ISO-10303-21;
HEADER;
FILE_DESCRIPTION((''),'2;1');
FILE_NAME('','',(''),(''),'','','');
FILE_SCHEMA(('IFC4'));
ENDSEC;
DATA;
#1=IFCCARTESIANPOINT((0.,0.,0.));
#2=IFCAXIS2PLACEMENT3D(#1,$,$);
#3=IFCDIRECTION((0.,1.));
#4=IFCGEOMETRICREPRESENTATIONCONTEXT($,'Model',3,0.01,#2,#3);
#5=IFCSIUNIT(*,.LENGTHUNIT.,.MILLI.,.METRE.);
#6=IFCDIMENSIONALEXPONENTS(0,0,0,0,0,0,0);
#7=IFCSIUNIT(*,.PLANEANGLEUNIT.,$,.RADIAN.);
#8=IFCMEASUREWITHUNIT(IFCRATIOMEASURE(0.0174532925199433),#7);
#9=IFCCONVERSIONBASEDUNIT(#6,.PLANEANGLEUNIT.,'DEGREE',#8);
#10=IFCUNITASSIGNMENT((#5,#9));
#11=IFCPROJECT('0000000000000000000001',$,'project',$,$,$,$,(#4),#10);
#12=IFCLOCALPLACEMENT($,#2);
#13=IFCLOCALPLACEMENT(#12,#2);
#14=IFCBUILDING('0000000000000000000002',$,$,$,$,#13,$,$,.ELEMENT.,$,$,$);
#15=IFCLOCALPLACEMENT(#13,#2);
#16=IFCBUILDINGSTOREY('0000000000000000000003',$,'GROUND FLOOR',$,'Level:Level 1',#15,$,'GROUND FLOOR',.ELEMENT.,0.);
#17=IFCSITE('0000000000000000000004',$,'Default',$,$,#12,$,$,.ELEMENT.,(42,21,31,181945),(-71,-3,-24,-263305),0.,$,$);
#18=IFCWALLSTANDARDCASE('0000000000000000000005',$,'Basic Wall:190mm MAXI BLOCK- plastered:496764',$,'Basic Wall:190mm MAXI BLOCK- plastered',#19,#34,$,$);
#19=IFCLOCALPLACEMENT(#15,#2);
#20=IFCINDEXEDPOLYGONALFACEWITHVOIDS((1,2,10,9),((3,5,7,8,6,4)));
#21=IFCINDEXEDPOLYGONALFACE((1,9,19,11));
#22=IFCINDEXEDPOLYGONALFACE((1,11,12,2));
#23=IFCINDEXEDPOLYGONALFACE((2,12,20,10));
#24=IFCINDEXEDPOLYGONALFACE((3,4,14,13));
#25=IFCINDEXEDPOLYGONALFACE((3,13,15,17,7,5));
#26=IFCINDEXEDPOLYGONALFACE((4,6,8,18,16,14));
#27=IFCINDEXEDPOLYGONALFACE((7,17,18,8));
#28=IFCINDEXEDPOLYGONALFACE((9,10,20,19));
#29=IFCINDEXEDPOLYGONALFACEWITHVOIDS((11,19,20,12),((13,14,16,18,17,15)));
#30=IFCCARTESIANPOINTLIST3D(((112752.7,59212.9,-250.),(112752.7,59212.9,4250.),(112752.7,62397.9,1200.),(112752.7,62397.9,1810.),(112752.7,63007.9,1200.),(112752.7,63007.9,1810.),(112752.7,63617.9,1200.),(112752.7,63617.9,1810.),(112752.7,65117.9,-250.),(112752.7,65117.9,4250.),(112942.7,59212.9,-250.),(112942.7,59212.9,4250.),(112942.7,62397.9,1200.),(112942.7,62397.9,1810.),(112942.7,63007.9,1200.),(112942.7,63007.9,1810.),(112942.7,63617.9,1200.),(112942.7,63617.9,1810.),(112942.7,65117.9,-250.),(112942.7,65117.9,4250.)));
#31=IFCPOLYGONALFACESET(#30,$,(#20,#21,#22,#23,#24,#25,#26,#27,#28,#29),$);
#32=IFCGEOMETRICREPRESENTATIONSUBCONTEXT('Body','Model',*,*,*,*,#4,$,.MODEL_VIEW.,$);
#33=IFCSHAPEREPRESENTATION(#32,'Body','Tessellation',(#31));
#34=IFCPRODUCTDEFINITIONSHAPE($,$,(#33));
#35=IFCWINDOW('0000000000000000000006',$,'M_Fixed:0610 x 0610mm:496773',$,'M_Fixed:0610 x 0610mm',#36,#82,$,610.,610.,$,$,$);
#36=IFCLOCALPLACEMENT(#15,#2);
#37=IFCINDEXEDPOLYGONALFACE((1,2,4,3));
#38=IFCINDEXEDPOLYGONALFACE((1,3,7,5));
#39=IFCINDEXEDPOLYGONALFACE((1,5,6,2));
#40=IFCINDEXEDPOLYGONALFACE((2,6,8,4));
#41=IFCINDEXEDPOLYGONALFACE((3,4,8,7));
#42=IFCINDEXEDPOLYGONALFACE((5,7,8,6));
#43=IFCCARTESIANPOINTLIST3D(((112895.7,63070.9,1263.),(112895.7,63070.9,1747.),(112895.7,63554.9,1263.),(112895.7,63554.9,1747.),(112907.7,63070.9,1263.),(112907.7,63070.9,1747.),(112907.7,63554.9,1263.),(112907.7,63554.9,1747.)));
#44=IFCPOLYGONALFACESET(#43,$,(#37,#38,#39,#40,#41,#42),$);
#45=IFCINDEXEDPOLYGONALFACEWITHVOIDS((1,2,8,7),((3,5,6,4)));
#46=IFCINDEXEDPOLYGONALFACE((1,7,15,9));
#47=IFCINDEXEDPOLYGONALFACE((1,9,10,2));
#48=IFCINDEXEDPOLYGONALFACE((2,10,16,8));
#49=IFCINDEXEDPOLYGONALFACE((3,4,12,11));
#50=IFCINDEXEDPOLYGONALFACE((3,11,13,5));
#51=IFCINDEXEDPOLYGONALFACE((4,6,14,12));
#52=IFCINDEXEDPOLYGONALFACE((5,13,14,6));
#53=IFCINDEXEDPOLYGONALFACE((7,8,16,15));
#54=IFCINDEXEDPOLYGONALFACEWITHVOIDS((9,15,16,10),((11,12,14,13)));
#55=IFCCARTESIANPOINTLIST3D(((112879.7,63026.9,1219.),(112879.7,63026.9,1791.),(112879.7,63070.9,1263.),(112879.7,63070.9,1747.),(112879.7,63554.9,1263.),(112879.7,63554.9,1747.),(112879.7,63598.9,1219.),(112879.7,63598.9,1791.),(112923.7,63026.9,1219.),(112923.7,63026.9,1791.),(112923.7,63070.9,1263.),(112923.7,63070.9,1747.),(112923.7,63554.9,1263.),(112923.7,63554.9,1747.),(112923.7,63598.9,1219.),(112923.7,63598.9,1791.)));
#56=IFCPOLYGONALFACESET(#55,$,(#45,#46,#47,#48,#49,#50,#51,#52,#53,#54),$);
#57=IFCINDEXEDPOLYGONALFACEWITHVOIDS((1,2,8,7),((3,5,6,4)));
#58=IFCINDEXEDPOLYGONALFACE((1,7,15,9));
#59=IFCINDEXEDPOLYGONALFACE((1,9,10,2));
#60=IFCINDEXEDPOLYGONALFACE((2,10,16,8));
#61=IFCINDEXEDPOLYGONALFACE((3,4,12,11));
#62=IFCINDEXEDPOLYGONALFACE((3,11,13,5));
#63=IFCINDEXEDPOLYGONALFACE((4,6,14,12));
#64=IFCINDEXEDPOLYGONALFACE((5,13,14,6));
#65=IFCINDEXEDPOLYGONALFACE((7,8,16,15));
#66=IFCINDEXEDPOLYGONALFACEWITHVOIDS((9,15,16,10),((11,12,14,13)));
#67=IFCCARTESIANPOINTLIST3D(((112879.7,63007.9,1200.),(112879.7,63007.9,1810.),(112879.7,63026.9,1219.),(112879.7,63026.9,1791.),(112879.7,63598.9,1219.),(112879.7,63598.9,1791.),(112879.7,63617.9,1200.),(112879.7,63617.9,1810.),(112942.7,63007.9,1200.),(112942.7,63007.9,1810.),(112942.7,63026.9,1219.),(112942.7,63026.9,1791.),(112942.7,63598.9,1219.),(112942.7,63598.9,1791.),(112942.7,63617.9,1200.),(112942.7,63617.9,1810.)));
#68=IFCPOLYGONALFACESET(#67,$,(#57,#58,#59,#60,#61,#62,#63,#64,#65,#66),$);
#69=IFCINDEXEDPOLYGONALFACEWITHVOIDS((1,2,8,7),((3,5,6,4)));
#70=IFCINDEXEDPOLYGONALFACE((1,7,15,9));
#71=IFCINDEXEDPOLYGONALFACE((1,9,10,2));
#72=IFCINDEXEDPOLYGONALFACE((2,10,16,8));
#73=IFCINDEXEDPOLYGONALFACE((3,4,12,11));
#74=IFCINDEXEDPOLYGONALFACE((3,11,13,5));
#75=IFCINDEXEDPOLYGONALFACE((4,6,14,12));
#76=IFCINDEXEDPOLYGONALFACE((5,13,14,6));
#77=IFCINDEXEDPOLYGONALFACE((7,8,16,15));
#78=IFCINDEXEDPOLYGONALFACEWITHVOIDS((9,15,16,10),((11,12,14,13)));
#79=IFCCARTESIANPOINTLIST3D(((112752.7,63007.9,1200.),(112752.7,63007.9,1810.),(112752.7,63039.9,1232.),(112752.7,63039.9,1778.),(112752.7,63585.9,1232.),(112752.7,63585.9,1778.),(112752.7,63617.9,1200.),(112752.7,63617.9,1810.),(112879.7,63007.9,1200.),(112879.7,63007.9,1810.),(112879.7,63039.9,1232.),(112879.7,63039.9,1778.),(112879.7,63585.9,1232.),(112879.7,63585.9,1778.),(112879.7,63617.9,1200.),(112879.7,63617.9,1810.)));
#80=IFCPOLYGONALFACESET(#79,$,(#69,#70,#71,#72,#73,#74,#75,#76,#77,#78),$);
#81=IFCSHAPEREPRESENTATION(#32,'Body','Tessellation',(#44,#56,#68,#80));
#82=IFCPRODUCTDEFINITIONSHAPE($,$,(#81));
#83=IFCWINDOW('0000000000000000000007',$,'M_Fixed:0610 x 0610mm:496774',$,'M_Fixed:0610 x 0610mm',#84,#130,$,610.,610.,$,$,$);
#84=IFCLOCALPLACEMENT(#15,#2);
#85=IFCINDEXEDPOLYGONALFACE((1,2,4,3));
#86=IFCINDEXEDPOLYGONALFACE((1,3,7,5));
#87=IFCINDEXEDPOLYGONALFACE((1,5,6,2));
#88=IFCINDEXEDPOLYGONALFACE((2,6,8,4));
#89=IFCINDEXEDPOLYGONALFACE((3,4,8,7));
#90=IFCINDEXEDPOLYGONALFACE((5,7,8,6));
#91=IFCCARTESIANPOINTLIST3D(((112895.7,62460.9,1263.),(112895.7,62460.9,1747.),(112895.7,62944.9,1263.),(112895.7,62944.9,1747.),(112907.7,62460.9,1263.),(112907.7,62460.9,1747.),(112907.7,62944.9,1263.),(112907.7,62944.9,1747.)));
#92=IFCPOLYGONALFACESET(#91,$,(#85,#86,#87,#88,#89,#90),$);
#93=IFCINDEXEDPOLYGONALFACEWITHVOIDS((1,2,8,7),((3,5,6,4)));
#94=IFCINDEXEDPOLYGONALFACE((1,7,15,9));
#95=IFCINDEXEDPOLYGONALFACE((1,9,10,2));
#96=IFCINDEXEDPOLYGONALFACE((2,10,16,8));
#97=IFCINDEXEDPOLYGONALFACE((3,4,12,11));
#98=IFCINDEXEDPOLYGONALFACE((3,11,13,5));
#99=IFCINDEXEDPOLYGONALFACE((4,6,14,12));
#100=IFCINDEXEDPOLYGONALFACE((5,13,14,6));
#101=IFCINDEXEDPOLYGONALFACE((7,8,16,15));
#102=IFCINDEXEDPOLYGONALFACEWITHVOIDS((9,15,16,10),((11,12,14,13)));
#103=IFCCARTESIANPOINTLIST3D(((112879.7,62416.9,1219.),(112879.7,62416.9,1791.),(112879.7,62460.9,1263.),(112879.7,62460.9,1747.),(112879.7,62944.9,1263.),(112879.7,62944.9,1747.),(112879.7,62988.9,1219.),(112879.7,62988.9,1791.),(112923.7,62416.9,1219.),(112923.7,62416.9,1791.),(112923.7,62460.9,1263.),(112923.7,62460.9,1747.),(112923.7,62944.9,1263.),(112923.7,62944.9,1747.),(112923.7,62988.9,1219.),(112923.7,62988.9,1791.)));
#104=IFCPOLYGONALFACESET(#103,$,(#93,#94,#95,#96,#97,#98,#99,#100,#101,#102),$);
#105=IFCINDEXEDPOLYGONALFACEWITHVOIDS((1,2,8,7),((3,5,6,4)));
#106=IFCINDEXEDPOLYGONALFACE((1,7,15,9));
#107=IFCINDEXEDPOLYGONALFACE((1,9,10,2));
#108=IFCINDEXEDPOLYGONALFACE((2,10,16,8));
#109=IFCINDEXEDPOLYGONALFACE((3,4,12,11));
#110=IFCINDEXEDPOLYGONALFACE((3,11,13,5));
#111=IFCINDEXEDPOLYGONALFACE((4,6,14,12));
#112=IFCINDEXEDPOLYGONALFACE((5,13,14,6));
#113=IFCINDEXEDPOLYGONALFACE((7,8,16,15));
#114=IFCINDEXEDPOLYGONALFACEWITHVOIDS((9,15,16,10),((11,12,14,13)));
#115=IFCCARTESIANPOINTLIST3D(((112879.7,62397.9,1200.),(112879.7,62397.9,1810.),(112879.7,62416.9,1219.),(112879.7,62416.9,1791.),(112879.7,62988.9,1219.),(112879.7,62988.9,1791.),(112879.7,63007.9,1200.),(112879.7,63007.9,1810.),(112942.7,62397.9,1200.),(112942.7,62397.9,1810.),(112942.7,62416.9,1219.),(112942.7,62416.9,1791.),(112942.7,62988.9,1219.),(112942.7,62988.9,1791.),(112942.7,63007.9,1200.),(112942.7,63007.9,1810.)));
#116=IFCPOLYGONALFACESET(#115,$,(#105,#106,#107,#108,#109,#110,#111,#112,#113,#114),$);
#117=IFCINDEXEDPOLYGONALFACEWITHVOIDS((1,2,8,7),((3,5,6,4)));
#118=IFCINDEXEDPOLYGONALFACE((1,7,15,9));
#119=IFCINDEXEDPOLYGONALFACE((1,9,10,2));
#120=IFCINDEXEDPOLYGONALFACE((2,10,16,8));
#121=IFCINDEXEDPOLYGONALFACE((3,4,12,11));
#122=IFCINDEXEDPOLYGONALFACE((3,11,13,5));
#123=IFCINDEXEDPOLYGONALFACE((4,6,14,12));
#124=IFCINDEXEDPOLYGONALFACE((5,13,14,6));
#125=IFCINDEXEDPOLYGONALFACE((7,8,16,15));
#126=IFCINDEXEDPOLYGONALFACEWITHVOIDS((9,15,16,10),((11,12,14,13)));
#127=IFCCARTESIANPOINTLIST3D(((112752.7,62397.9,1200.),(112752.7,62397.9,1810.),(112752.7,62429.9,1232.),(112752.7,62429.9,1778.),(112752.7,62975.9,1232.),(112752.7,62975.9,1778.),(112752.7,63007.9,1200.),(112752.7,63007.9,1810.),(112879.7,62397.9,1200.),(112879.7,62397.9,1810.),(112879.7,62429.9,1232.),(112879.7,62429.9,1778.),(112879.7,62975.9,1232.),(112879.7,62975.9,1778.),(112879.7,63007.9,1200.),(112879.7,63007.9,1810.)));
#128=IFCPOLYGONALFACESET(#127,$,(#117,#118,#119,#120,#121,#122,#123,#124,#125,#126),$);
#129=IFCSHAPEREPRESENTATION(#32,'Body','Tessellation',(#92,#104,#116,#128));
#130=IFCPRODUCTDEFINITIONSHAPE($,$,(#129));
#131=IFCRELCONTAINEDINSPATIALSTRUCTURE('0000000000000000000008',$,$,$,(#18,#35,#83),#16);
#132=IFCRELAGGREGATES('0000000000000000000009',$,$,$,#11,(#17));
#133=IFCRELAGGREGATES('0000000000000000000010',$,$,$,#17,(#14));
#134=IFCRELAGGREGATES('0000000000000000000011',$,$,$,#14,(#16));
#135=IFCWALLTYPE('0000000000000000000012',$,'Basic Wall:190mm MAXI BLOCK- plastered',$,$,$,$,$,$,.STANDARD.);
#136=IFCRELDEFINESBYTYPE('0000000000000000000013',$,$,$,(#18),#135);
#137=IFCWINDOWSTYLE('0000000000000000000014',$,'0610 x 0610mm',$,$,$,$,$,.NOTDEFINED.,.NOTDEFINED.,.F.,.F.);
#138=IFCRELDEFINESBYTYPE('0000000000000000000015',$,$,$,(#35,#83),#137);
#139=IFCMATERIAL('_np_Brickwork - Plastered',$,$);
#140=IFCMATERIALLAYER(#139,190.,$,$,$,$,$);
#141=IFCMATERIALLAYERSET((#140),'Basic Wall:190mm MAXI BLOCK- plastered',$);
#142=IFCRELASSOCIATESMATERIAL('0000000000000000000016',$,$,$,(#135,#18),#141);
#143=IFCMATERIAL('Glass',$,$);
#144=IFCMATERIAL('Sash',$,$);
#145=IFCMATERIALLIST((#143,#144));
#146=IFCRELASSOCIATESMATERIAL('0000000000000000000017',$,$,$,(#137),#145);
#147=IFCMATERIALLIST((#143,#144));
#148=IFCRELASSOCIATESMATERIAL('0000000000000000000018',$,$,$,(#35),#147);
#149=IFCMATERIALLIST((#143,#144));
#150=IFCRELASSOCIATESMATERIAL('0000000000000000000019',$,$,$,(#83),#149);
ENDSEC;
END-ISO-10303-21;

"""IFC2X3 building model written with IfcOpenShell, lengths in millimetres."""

from ifc_helpers import new_model, entity, si_unit, converted_unit, direction, frame, frame_2d, origin, place, context, subcontext, project, spatial, polyline, rectangle, outline, extrude, source, transform, mapped, material, material_list, layer, layer_set, layer_usage, type_object, type_shapes, element, fill, save


model = new_model("IFC2X3")

# Units and contexts
model_context = context("Model", 3, precision=0.01, world=origin(), true_north=direction((0.0, 1.0)))
body_context = subcontext(model_context, "Body", "Model", "MODEL_VIEW")
ifc_project = project(units=[si_unit("LENGTHUNIT", "METRE", prefix="MILLI"), converted_unit("PLANEANGLEUNIT", "DEGREE", entity("IfcRatioMeasure", 0.0174532925199433), si_unit("PLANEANGLEUNIT", "RADIAN"), dimensions=[0, 0, 0, 0, 0, 0, 0])], contexts=[model_context])

# Site, building, storey
site_placement = place(None, origin())
site = spatial("IfcSite", under=ifc_project, at=site_placement, Name="Default", CompositionType="ELEMENT", RefLatitude=(42, 21, 31, 181945), RefLongitude=(-71, -3, -24, -263305), RefElevation=0.0)
building_placement = place(site_placement, origin())
building = spatial("IfcBuilding", under=site, at=building_placement, CompositionType="ELEMENT")
storey_placement = place(building_placement, origin())
storey = spatial("IfcBuildingStorey", under=building, at=storey_placement, Name="GROUND FLOOR", ObjectType="Level:Level 1", LongName="GROUND FLOOR", CompositionType="ELEMENT", Elevation=0.0)

# Wall, openings, windows
ifc_material_1 = material(Name="_np_Brickwork - Plastered")
ifc_layer = layer(ifc_material_1, 190.0)
ifc_layer_set = layer_set([ifc_layer], Name="Basic Wall:190mm MAXI BLOCK- plastered")
wall_type = type_object("IfcWallType", Name="Basic Wall:190mm MAXI BLOCK- plastered", PredefinedType="STANDARD", material=ifc_layer_set)
ifc_material_2 = material(Name="Glass")
ifc_material_3 = material(Name="Sash")
ifc_material_list_1 = material_list([ifc_material_2, ifc_material_3])
window_style = type_object("IfcWindowStyle", Name="0610 x 0610mm", ConstructionType="NOTDEFINED", OperationType="NOTDEFINED", ParameterTakesPrecedence=False, Sizeable=False, material=ifc_material_list_1)
shared_shape = source(origin(), body_context, "Body", "SweptSolid", [
    extrude(rectangle(XDim=12.0, YDim=484.0, at=frame_2d((0.0, 0.0), x_axis=(1.0, 0.0))), frame((305.0, 149.0, 63.0), z_axis=(0.0, 0.0, 1.0), x_axis=(0.0, -1.0, 0.0)), (0.0, 0.0, 1.0), 484.0),
    extrude(outline(polyline([(-286.0, -286.0), (286.0, -286.0), (286.0, 286.0), (-286.0, 286.0), (-286.0, -286.0)]), holes=[polyline([(-242.0, -242.0), (-242.0, 242.0), (242.0, 242.0), (242.0, -242.0), (-242.0, -242.0)])]), frame((305.0, 127.0, 305.0), z_axis=(0.0, 1.0, 0.0), x_axis=(1.0, 0.0, 0.0)), (0.0, 0.0, 1.0), 44.0),
    extrude(outline(polyline([(-305.0, -305.0), (305.0, -305.0), (305.0, 305.0), (-305.0, 305.0), (-305.0, -305.0)]), holes=[polyline([(-286.0, -286.0), (-286.0, 286.0), (286.0, 286.0), (286.0, -286.0), (-286.0, -286.0)])]), frame((305.0, 127.0, 305.0), z_axis=(0.0, 1.0, 0.0), x_axis=(1.0, 0.0, 0.0)), (0.0, 0.0, 1.0), 63.0),
    extrude(outline(polyline([(-305.0, -305.0), (305.0, -305.0), (305.0, 305.0), (-305.0, 305.0), (-305.0, -305.0)]), holes=[polyline([(-273.0, -273.0), (-273.0, 273.0), (273.0, 273.0), (273.0, -273.0), (-273.0, -273.0)])]), frame((305.0, 0.0, 305.0), z_axis=(0.0, 1.0, 0.0), x_axis=(1.0, 0.0, 0.0)), (0.0, 0.0, 1.0), 127.0),
])
type_shapes(window_style, [shared_shape])
ifc_layer_usage_1 = layer_usage(ifc_layer_set, "AXIS2", "NEGATIVE", 95.0)
wall_1_placement = place(storey_placement, frame((112847.7, 59212.9, -250.0), z_axis=(0.0, 0.0, 1.0), x_axis=(0.0, 1.0, 0.0)))
wall_1 = element("IfcWallStandardCase", 1, at=wall_1_placement, inside=storey, type_object=wall_type, material=ifc_layer_usage_1, Name="Basic Wall:190mm MAXI BLOCK- plastered:496764", ObjectType="Basic Wall:190mm MAXI BLOCK- plastered", context=body_context, shape_type="SweptSolid", body=[
    extrude(rectangle(XDim=5905.0, YDim=190.0, at=frame_2d((2952.5, 0.0), x_axis=(-1.0, 0.0))), origin(), (0.0, 0.0, 1.0), 4500.0),
])
opening_1_placement = place(wall_1_placement, frame((4405.0, 95.0, 1450.0)))
opening_1 = element("IfcOpeningElement", 2, at=opening_1_placement, cuts=wall_1, ObjectType="Opening", context=body_context, shape_type="SweptSolid", body=[
    extrude(rectangle(XDim=610.0, YDim=610.0, at=frame_2d((305.0, 305.0), x_axis=(1.0, 0.0))), frame((0.0, 0.0, 0.0), z_axis=(0.0, -1.0, 0.0), x_axis=(0.0, 0.0, 1.0)), (0.0, 0.0, 1.0), 190.0),
])
opening_2_placement = place(wall_1_placement, frame((3795.0, 95.0, 1450.0)))
opening_2 = element("IfcOpeningElement", 3, at=opening_2_placement, cuts=wall_1, ObjectType="Opening", context=body_context, shape_type="SweptSolid", body=[
    extrude(rectangle(XDim=610.0, YDim=610.0, at=frame_2d((305.0, 305.0), x_axis=(1.0, 0.0))), frame((0.0, 0.0, 0.0), z_axis=(0.0, -1.0, 0.0), x_axis=(0.0, 0.0, 1.0)), (0.0, 0.0, 1.0), 190.0),
])
ifc_material_list_2 = material_list([ifc_material_2, ifc_material_3])
window_1_placement = place(opening_1_placement, frame((0.0, 0.0, 0.0), z_axis=(0.0, 0.0, 1.0), x_axis=(-1.0, 0.0, 0.0)))
window_1 = element("IfcWindow", 4, at=window_1_placement, inside=storey, type_object=window_style, material=ifc_material_list_2, Name="M_Fixed:0610 x 0610mm:496773", ObjectType="M_Fixed:0610 x 0610mm", OverallHeight=610.0, OverallWidth=610.0, context=body_context, shape_type="MappedRepresentation", body=[
    mapped(shared_shape, transform((0.0, 0.0, 0.0), scale=1.0)),
])
fill(opening_1, window_1)
ifc_material_list_3 = material_list([ifc_material_2, ifc_material_3])
window_2_placement = place(opening_2_placement, frame((0.0, 0.0, 0.0), z_axis=(0.0, 0.0, 1.0), x_axis=(-1.0, 0.0, 0.0)))
window_2 = element("IfcWindow", 5, at=window_2_placement, inside=storey, type_object=window_style, material=ifc_material_list_3, Name="M_Fixed:0610 x 0610mm:496774", ObjectType="M_Fixed:0610 x 0610mm", OverallHeight=610.0, OverallWidth=610.0, context=body_context, shape_type="MappedRepresentation", body=[
    mapped(shared_shape, transform((0.0, 0.0, 0.0), scale=1.0)),
])
fill(opening_2, window_2)

save(model, "model.ifc")
